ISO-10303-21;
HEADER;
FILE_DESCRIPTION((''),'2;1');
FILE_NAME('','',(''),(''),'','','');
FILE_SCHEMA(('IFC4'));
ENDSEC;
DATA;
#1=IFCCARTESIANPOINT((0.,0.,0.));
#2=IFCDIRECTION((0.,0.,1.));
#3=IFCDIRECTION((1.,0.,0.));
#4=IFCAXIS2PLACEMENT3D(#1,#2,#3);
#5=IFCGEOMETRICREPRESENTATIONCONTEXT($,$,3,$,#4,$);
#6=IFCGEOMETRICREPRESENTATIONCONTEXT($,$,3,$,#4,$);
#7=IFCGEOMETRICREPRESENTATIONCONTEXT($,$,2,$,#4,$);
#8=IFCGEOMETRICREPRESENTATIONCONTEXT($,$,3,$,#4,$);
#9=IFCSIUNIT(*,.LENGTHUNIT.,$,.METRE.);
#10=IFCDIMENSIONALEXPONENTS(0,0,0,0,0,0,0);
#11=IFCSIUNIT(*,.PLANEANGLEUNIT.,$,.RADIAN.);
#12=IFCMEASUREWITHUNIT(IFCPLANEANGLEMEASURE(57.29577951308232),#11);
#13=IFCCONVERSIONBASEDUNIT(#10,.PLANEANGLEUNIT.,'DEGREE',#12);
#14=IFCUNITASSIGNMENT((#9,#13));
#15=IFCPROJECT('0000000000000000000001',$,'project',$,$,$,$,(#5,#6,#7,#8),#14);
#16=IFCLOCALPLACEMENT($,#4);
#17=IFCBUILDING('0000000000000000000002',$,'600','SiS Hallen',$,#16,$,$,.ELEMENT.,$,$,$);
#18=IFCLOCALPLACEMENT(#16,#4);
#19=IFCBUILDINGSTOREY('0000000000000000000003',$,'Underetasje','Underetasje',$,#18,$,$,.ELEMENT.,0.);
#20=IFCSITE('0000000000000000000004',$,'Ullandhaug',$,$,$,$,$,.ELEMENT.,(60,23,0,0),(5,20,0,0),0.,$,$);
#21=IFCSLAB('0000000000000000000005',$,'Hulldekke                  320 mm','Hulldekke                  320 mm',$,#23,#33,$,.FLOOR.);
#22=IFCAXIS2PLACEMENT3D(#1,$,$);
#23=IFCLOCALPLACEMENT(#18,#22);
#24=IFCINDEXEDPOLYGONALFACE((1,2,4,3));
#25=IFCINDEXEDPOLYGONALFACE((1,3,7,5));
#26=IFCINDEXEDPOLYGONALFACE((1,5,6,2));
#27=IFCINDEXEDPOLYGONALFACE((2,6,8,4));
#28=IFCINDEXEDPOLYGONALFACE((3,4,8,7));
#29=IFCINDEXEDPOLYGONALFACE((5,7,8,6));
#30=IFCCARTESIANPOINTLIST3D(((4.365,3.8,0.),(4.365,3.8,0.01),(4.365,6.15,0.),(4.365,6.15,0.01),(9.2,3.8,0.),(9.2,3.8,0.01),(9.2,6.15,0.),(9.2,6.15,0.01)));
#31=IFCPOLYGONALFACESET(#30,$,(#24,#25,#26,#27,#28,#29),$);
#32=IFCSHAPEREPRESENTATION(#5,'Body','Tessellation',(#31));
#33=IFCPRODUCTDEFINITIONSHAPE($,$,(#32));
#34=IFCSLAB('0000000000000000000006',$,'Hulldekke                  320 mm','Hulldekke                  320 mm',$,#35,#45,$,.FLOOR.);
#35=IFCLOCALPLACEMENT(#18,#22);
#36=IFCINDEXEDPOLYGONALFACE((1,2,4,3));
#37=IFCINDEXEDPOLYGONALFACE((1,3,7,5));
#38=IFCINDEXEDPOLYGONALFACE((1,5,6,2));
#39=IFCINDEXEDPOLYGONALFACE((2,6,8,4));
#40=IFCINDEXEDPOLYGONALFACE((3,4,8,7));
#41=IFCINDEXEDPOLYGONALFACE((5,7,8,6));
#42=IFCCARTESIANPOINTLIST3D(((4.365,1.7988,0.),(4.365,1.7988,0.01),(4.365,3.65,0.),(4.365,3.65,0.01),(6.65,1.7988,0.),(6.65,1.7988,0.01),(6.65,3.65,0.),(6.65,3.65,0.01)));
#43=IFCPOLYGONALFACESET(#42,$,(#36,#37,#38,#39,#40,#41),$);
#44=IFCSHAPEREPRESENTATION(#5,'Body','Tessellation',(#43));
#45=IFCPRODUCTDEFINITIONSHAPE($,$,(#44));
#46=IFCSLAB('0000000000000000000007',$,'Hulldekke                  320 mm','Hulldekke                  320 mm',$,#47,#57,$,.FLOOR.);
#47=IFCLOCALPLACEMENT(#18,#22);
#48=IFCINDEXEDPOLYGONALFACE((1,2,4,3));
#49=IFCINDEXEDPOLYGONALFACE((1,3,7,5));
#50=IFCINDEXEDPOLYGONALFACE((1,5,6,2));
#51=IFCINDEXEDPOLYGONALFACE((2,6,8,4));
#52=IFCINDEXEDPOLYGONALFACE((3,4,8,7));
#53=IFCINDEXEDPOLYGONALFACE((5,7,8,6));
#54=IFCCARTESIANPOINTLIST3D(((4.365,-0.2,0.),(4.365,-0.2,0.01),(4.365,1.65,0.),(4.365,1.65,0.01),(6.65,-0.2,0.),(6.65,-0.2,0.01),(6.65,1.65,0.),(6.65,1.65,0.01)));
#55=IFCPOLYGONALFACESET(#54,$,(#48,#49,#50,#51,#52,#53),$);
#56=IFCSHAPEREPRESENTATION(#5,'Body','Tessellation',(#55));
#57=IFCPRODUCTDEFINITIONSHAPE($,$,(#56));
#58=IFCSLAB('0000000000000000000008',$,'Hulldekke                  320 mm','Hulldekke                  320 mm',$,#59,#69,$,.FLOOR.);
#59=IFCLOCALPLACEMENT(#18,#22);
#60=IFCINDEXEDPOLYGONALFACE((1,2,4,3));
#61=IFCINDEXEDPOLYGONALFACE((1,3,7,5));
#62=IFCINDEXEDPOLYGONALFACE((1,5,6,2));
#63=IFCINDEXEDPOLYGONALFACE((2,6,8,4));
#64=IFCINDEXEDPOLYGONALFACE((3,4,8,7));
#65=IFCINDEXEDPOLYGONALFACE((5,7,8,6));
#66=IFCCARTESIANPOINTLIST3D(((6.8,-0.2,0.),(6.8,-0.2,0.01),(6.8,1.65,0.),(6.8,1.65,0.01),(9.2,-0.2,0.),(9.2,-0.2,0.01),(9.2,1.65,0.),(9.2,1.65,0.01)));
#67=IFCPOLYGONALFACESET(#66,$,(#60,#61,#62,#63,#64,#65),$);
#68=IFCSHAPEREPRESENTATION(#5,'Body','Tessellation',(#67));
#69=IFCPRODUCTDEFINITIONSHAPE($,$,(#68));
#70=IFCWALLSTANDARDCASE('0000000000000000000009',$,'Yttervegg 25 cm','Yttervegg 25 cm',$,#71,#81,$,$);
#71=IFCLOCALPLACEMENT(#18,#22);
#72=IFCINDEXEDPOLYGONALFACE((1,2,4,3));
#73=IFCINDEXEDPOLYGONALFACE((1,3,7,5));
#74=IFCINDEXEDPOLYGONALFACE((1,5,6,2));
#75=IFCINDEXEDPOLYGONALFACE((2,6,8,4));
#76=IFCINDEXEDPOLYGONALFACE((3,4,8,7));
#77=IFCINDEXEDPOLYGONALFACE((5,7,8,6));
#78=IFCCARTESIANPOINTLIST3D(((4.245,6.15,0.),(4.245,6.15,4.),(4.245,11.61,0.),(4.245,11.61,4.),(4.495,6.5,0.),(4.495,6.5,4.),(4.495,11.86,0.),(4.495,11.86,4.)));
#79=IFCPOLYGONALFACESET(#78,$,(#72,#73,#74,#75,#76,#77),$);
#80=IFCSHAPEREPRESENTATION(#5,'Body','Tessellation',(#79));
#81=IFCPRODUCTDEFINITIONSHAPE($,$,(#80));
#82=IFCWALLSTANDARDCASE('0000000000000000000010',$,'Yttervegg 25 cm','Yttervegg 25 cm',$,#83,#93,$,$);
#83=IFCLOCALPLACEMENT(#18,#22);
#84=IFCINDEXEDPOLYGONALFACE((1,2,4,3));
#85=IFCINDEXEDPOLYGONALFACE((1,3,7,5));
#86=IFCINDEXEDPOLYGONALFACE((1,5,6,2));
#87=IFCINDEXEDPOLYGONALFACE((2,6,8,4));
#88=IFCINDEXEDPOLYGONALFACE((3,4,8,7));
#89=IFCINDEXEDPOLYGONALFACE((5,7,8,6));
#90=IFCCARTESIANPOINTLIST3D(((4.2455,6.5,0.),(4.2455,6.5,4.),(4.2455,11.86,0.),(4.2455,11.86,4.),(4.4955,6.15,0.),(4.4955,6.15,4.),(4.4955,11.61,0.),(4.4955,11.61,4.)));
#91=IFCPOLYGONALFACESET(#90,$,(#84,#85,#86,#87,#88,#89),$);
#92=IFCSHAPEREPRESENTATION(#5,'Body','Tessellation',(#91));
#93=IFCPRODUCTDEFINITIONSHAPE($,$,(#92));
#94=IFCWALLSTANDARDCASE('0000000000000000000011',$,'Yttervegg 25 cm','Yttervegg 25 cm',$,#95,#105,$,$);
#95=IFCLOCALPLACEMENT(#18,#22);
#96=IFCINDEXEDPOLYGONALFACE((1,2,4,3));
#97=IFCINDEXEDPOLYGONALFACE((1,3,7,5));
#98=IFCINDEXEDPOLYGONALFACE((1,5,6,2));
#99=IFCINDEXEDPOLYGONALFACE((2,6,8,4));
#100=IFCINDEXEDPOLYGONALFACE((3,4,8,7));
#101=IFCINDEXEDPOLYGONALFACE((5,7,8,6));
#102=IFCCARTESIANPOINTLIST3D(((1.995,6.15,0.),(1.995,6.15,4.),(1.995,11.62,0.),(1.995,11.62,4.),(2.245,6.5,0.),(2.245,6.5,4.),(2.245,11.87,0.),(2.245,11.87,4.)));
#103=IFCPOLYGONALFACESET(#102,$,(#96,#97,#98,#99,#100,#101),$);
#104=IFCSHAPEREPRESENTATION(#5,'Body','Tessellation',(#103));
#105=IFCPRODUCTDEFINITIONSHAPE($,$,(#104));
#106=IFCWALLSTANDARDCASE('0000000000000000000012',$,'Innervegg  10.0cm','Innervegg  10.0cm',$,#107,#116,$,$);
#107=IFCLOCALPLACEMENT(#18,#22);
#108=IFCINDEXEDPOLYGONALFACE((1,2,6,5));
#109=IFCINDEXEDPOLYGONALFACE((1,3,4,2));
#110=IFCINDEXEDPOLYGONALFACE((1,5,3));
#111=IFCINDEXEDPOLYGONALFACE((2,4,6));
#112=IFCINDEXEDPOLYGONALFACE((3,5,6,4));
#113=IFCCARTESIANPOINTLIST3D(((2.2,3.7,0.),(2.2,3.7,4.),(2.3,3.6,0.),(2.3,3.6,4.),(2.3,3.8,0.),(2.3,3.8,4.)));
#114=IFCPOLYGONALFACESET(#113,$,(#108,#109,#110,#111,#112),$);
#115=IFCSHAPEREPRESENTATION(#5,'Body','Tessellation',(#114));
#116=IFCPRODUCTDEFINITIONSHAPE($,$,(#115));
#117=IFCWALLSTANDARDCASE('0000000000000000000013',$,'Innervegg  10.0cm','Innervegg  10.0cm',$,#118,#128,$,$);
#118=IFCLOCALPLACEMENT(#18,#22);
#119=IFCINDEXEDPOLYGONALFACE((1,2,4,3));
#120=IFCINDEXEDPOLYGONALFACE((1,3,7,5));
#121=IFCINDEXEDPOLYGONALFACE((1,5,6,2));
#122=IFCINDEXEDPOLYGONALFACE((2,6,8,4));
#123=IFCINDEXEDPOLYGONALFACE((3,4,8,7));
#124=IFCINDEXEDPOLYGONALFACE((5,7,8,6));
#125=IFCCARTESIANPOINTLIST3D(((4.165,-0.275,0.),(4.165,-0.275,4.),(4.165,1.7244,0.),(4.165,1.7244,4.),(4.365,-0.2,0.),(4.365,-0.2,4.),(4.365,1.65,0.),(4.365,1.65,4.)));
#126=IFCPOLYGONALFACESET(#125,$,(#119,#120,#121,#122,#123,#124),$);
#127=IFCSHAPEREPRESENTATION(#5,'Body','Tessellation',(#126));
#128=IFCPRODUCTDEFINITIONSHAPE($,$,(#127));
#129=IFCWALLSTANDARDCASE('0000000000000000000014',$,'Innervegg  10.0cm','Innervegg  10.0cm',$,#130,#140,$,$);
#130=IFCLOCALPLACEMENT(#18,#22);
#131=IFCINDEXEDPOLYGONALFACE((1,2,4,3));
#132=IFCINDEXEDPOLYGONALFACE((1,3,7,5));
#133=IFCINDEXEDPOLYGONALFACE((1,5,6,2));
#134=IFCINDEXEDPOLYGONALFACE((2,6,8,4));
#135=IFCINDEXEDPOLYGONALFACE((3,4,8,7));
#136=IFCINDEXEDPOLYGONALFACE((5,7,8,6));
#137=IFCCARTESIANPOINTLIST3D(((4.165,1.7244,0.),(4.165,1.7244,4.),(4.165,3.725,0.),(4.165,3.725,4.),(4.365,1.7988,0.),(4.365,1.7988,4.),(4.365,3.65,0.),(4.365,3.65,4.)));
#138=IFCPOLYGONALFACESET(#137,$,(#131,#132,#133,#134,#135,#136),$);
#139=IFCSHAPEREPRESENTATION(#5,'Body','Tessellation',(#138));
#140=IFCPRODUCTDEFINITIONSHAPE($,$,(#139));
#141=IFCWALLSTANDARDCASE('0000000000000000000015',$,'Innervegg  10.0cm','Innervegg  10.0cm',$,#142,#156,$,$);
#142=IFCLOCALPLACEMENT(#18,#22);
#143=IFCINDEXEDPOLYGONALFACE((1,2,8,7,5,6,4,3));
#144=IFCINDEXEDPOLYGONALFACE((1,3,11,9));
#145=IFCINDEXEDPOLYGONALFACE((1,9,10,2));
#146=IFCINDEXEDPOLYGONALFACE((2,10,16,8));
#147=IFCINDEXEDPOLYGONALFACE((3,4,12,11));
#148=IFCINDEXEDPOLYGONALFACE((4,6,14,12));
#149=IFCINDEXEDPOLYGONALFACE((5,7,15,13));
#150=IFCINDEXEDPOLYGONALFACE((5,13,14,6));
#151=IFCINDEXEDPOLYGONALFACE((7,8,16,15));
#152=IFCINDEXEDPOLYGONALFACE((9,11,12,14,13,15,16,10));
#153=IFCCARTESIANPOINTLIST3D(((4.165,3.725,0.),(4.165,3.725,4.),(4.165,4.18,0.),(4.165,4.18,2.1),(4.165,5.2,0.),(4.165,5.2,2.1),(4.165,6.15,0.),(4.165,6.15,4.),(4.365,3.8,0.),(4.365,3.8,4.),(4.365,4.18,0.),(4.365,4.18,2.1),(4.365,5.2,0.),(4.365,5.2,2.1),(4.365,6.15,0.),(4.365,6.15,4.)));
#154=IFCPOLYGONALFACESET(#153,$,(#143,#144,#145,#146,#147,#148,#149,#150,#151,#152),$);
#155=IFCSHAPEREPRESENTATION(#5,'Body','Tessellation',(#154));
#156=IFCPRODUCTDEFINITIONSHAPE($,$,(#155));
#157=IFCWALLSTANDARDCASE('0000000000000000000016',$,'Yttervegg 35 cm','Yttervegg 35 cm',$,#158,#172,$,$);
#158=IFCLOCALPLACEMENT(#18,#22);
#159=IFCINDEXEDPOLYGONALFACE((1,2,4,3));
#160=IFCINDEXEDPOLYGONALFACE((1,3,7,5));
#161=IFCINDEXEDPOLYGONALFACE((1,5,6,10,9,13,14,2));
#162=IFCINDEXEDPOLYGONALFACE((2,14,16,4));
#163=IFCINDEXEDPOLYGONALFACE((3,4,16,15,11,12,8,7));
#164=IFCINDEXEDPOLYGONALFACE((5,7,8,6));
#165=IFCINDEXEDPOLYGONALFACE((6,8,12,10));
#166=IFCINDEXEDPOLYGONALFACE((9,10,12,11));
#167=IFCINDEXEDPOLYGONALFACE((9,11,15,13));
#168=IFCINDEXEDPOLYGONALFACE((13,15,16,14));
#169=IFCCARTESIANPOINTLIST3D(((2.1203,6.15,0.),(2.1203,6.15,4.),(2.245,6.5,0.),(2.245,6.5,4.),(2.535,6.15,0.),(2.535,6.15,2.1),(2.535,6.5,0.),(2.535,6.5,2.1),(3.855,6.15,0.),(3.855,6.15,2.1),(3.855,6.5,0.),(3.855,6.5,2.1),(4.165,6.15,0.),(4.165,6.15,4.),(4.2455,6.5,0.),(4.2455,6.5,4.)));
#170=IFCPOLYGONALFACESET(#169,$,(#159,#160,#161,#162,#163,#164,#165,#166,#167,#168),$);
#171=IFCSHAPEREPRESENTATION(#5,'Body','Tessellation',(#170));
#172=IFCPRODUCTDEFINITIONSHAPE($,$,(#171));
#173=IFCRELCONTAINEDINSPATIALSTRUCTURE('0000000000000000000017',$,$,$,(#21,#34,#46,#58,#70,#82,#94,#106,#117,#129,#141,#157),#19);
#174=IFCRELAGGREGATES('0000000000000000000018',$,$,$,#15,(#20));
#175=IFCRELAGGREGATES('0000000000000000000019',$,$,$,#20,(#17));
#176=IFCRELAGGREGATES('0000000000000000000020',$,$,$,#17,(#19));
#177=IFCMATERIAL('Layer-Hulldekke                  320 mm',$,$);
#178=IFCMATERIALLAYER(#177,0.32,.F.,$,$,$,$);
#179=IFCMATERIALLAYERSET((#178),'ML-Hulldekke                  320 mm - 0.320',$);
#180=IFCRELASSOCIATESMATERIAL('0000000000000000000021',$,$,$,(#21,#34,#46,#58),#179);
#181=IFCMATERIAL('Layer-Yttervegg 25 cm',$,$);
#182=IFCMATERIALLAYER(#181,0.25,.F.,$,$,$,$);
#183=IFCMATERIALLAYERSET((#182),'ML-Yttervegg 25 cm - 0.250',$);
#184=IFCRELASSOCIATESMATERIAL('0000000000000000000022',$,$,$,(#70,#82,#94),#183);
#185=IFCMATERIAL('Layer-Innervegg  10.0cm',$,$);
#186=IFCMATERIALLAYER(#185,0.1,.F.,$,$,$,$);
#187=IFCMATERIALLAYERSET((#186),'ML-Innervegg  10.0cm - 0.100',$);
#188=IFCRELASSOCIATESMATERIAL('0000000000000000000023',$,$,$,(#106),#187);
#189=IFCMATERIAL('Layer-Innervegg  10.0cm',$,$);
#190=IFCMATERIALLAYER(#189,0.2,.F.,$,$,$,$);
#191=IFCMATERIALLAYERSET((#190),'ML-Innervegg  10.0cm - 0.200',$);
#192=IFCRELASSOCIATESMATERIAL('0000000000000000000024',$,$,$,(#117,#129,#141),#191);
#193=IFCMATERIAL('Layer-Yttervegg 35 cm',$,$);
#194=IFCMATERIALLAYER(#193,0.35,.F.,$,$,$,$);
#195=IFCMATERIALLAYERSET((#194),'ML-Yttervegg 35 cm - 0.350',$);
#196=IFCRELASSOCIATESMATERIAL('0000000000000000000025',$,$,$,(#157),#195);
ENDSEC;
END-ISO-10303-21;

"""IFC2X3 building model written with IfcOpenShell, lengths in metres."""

from ifc_helpers import new_model, entity, si_unit, converted_unit, frame, origin_with_axes, place, context, project, spatial, polyline, outline, extrude, material, layer, layer_set, layer_usage, element, save


model = new_model("IFC2X3")

# Units and contexts
context_of_model_1 = context(None, 3, world=origin_with_axes())
context_of_model_2 = context(None, 3, world=origin_with_axes())
context_of_model_3 = context(None, 2, world=origin_with_axes())
context_of_model_4 = context(None, 3, world=origin_with_axes())
ifc_project = project(units=[si_unit("LENGTHUNIT", "METRE"), converted_unit("PLANEANGLEUNIT", "DEGREE", entity("IfcPlaneAngleMeasure", 57.29577951308232), si_unit("PLANEANGLEUNIT", "RADIAN"), dimensions=[0, 0, 0, 0, 0, 0, 0])], contexts=[context_of_model_1, context_of_model_2, context_of_model_3, context_of_model_4])

# Site, building, storey
site = spatial("IfcSite", under=ifc_project, Name="Ullandhaug", CompositionType="ELEMENT", RefLatitude=(60, 23, 0, 0), RefLongitude=(5, 20, 0, 0), RefElevation=0.0)
building_placement = place(None, origin_with_axes())
building = spatial("IfcBuilding", under=site, at=building_placement, Name="600", Description="SiS Hallen", CompositionType="ELEMENT")
storey_placement = place(building_placement, origin_with_axes())
storey = spatial("IfcBuildingStorey", under=building, at=storey_placement, Name="Underetasje", Description="Underetasje", CompositionType="ELEMENT", Elevation=0.0)

# Slabs
ifc_material_1 = material(Name="Layer-Hulldekke                  320 mm")
ifc_layer_1 = layer(ifc_material_1, 0.32, ventilated=False)
ifc_layer_set_1 = layer_set([ifc_layer_1], Name="ML-Hulldekke                  320 mm - 0.320")
ifc_layer_usage_1 = layer_usage(ifc_layer_set_1, "AXIS2", "POSITIVE", 0.0)
slab_1_placement = place(storey_placement, frame((4.365, 3.8, 0.0), z_axis=(0.0, 0.0, 1.0), x_axis=(1.0, 0.0, 0.0)))
element("IfcSlab", 1, at=slab_1_placement, inside=storey, material=ifc_layer_usage_1, Name="Hulldekke                  320 mm", Description="Hulldekke                  320 mm", PredefinedType="FLOOR", context=context_of_model_1, shape_type="SweptSolid", body=[
    extrude(outline(polyline([(0.0, 0.0), (4.835, 0.0), (4.835, 2.35), (0.0, 2.35), (0.0, 0.0)])), origin_with_axes(), (0.0, 0.0, 1.0), 0.01),
])
slab_2_placement = place(storey_placement, frame((4.365, 1.7988, 0.0), z_axis=(0.0, 0.0, 1.0), x_axis=(1.0, 0.0, 0.0)))
element("IfcSlab", 2, at=slab_2_placement, inside=storey, material=ifc_layer_usage_1, Name="Hulldekke                  320 mm", Description="Hulldekke                  320 mm", PredefinedType="FLOOR", context=context_of_model_1, shape_type="SweptSolid", body=[
    extrude(outline(polyline([(0.0, 0.0), (2.285, 0.0), (2.285, 1.8512), (0.0, 1.8512), (0.0, 0.0)])), origin_with_axes(), (0.0, 0.0, 1.0), 0.01),
])
slab_3_placement = place(storey_placement, frame((4.365, -0.2, 0.0), z_axis=(0.0, 0.0, 1.0), x_axis=(1.0, 0.0, 0.0)))
element("IfcSlab", 3, at=slab_3_placement, inside=storey, material=ifc_layer_usage_1, Name="Hulldekke                  320 mm", Description="Hulldekke                  320 mm", PredefinedType="FLOOR", context=context_of_model_1, shape_type="SweptSolid", body=[
    extrude(outline(polyline([(0.0, 0.0), (2.285, 0.0), (2.285, 1.85), (0.0, 1.85), (0.0, 0.0)])), origin_with_axes(), (0.0, 0.0, 1.0), 0.01),
])
slab_4_placement = place(storey_placement, frame((6.8, -0.2, 0.0), z_axis=(0.0, 0.0, 1.0), x_axis=(1.0, 0.0, 0.0)))
element("IfcSlab", 4, at=slab_4_placement, inside=storey, material=ifc_layer_usage_1, Name="Hulldekke                  320 mm", Description="Hulldekke                  320 mm", PredefinedType="FLOOR", context=context_of_model_1, shape_type="SweptSolid", body=[
    extrude(outline(polyline([(0.0, 0.0), (2.4, 0.0), (2.4, 1.85), (0.0, 1.85), (0.0, 0.0)])), origin_with_axes(), (0.0, 0.0, 1.0), 0.01),
])

# Walls
ifc_material_2 = material(Name="Layer-Yttervegg 25 cm")
ifc_layer_2 = layer(ifc_material_2, 0.25, ventilated=False)
ifc_layer_set_2 = layer_set([ifc_layer_2], Name="ML-Yttervegg 25 cm - 0.250")
ifc_layer_usage_2 = layer_usage(ifc_layer_set_2, "AXIS2", "POSITIVE", 0.0)
wall_1_placement = place(storey_placement, frame((4.495, 6.5, 0.0), z_axis=(0.0, 0.0, 1.0), x_axis=(0.0, 1.0, 0.0)))
element("IfcWallStandardCase", 5, at=wall_1_placement, inside=storey, material=ifc_layer_usage_2, Name="Yttervegg 25 cm", Description="Yttervegg 25 cm", context=context_of_model_1, shape_type="SweptSolid", body=[
    extrude(outline(polyline([(0.0, 0.0), (5.36, 0.0), (5.11, 0.25), (-0.35, 0.25), (0.0, 0.0)])), frame((0.0, 0.0, 0.0), z_axis=(0.0, 0.0, 1.0), x_axis=(1.0, 0.0, 0.0)), (0.0, 0.0, 1.0), 4.0),
])
wall_2_placement = place(storey_placement, frame((4.2455, 11.86, 0.0), z_axis=(0.0, 0.0, 1.0), x_axis=(0.0, -1.0, 0.0)))
element("IfcWallStandardCase", 6, at=wall_2_placement, inside=storey, material=ifc_layer_usage_2, Name="Yttervegg 25 cm", Description="Yttervegg 25 cm", context=context_of_model_1, shape_type="SweptSolid", body=[
    extrude(outline(polyline([(0.0, 0.0), (5.36, 0.0), (5.71, 0.25), (0.25, 0.25), (0.0, 0.0)])), frame((0.0, 0.0, 0.0), z_axis=(0.0, 0.0, 1.0), x_axis=(1.0, 0.0, 0.0)), (0.0, 0.0, 1.0), 4.0),
])
wall_3_placement = place(storey_placement, frame((2.245, 6.5, 0.0), z_axis=(0.0, 0.0, 1.0), x_axis=(0.0, 1.0, 0.0)))
element("IfcWallStandardCase", 7, at=wall_3_placement, inside=storey, material=ifc_layer_usage_2, Name="Yttervegg 25 cm", Description="Yttervegg 25 cm", context=context_of_model_1, shape_type="SweptSolid", body=[
    extrude(outline(polyline([(0.0, 0.0), (5.37, 0.0), (5.12, 0.25), (-0.35, 0.25), (0.0, 0.0)])), frame((0.0, 0.0, 0.0), z_axis=(0.0, 0.0, 1.0), x_axis=(1.0, 0.0, 0.0)), (0.0, 0.0, 1.0), 4.0),
])
ifc_material_3 = material(Name="Layer-Innervegg  10.0cm")
ifc_layer_3 = layer(ifc_material_3, 0.1, ventilated=False)
ifc_layer_set_3 = layer_set([ifc_layer_3], Name="ML-Innervegg  10.0cm - 0.100")
ifc_layer_usage_3 = layer_usage(ifc_layer_set_3, "AXIS2", "POSITIVE", 0.0)
wall_4_placement = place(storey_placement, frame((2.2, 3.7, 0.0), z_axis=(0.0, 0.0, 1.0), x_axis=(0.0, -1.0, 0.0)))
element("IfcWallStandardCase", 8, at=wall_4_placement, inside=storey, material=ifc_layer_usage_3, Name="Innervegg  10.0cm", Description="Innervegg  10.0cm", context=context_of_model_1, shape_type="SweptSolid", body=[
    extrude(outline(polyline([(0.0, 0.0), (0.0, 0.0), (0.1414, 0.0), (0.0, 0.1414), (0.0, 0.0)])), frame((0.0, 0.0, 0.0), z_axis=(0.0, 0.0, 1.0), x_axis=(0.707108, 0.707106, 0.0)), (0.0, 0.0, 1.0), 4.0),
])
ifc_material_4 = material(Name="Layer-Innervegg  10.0cm")
ifc_layer_4 = layer(ifc_material_4, 0.2, ventilated=False)
ifc_layer_set_4 = layer_set([ifc_layer_4], Name="ML-Innervegg  10.0cm - 0.200")
ifc_layer_usage_4 = layer_usage(ifc_layer_set_4, "AXIS2", "POSITIVE", 0.0)
wall_5_placement = place(storey_placement, frame((4.365, -0.2, 0.0), z_axis=(0.0, 0.0, 1.0), x_axis=(0.0, 1.0, 0.0)))
element("IfcWallStandardCase", 9, at=wall_5_placement, inside=storey, material=ifc_layer_usage_4, Name="Innervegg  10.0cm", Description="Innervegg  10.0cm", context=context_of_model_1, shape_type="SweptSolid", body=[
    extrude(outline(polyline([(0.0, 0.0), (1.85, 0.0), (1.9244, 0.2), (-0.075, 0.2), (0.0, 0.0)])), frame((0.0, 0.0, 0.0), z_axis=(0.0, 0.0, 1.0), x_axis=(1.0, 0.0, 0.0)), (0.0, 0.0, 1.0), 4.0),
])
wall_6_placement = place(storey_placement, frame((4.365, 1.7988, 0.0), z_axis=(0.0, 0.0, 1.0), x_axis=(0.0, 1.0, 0.0)))
element("IfcWallStandardCase", 10, at=wall_6_placement, inside=storey, material=ifc_layer_usage_4, Name="Innervegg  10.0cm", Description="Innervegg  10.0cm", context=context_of_model_1, shape_type="SweptSolid", body=[
    extrude(outline(polyline([(0.0, 0.0), (1.8512, 0.0), (1.9262, 0.2), (-0.0744, 0.2), (0.0, 0.0)])), frame((0.0, 0.0, 0.0), z_axis=(0.0, 0.0, 1.0), x_axis=(1.0, 0.0, 0.0)), (0.0, 0.0, 1.0), 4.0),
])

# Walls, openings
wall_7_placement = place(storey_placement, frame((4.365, 3.8, 0.0), z_axis=(0.0, 0.0, 1.0), x_axis=(0.0, 1.0, 0.0)))
wall_7 = element("IfcWallStandardCase", 11, at=wall_7_placement, inside=storey, material=ifc_layer_usage_4, Name="Innervegg  10.0cm", Description="Innervegg  10.0cm", context=context_of_model_1, shape_type="SweptSolid", body=[
    extrude(outline(polyline([(0.0, 0.0), (2.35, 0.0), (2.35, 0.2), (-0.075, 0.2), (0.0, 0.0)])), frame((0.0, 0.0, 0.0), z_axis=(0.0, 0.0, 1.0), x_axis=(1.0, 0.0, 0.0)), (0.0, 0.0, 1.0), 4.0),
])
opening_1_placement = place(wall_7_placement, frame((0.38, 0.2, 0.0), z_axis=(0.0, 0.0, 1.0), x_axis=(1.0, 0.0, 0.0)))
element("IfcOpeningElement", 12, at=opening_1_placement, cuts=wall_7, context=context_of_model_1, shape_type="SweptSolid", body=[
    extrude(outline(polyline([(0.0, 0.0), (2.1, 0.0), (2.1, 1.02), (0.0, 1.02), (0.0, 0.0)])), frame((0.0, 0.0, 0.0), z_axis=(0.0, 1.0, 0.0), x_axis=(0.0, 0.0, 1.0)), (0.0, 0.0, -1.0), 0.2),
])
ifc_material_5 = material(Name="Layer-Yttervegg 35 cm")
ifc_layer_5 = layer(ifc_material_5, 0.35, ventilated=False)
ifc_layer_set_5 = layer_set([ifc_layer_5], Name="ML-Yttervegg 35 cm - 0.350")
ifc_layer_usage_5 = layer_usage(ifc_layer_set_5, "AXIS2", "POSITIVE", 0.0)
wall_8_placement = place(storey_placement, frame((4.2455, 6.5, 0.0), z_axis=(0.0, 0.0, 1.0), x_axis=(-1.0, 0.0, 0.0)))
wall_8 = element("IfcWallStandardCase", 13, at=wall_8_placement, inside=storey, material=ifc_layer_usage_5, Name="Yttervegg 35 cm", Description="Yttervegg 35 cm", context=context_of_model_1, shape_type="SweptSolid", body=[
    extrude(outline(polyline([(0.0, 0.0), (2.0005, 0.0), (2.1253, 0.35), (0.0805, 0.35), (0.0, 0.0)])), frame((0.0, 0.0, 0.0), z_axis=(0.0, 0.0, 1.0), x_axis=(1.0, 0.0, 0.0)), (0.0, 0.0, 1.0), 4.0),
])
opening_2_placement = place(wall_8_placement, frame((0.3905, 0.35, 0.0), z_axis=(0.0, 0.0, 1.0), x_axis=(1.0, 0.0, 0.0)))
element("IfcOpeningElement", 14, at=opening_2_placement, cuts=wall_8, context=context_of_model_1, shape_type="SweptSolid", body=[
    extrude(outline(polyline([(0.0, 0.0), (2.1, 0.0), (2.1, 1.32), (0.0, 1.32), (0.0, 0.0)])), frame((0.0, 0.0, 0.0), z_axis=(0.0, 1.0, 0.0), x_axis=(0.0, 0.0, 1.0)), (0.0, 0.0, -1.0), 0.35),
])

save(model, "model.ifc")
